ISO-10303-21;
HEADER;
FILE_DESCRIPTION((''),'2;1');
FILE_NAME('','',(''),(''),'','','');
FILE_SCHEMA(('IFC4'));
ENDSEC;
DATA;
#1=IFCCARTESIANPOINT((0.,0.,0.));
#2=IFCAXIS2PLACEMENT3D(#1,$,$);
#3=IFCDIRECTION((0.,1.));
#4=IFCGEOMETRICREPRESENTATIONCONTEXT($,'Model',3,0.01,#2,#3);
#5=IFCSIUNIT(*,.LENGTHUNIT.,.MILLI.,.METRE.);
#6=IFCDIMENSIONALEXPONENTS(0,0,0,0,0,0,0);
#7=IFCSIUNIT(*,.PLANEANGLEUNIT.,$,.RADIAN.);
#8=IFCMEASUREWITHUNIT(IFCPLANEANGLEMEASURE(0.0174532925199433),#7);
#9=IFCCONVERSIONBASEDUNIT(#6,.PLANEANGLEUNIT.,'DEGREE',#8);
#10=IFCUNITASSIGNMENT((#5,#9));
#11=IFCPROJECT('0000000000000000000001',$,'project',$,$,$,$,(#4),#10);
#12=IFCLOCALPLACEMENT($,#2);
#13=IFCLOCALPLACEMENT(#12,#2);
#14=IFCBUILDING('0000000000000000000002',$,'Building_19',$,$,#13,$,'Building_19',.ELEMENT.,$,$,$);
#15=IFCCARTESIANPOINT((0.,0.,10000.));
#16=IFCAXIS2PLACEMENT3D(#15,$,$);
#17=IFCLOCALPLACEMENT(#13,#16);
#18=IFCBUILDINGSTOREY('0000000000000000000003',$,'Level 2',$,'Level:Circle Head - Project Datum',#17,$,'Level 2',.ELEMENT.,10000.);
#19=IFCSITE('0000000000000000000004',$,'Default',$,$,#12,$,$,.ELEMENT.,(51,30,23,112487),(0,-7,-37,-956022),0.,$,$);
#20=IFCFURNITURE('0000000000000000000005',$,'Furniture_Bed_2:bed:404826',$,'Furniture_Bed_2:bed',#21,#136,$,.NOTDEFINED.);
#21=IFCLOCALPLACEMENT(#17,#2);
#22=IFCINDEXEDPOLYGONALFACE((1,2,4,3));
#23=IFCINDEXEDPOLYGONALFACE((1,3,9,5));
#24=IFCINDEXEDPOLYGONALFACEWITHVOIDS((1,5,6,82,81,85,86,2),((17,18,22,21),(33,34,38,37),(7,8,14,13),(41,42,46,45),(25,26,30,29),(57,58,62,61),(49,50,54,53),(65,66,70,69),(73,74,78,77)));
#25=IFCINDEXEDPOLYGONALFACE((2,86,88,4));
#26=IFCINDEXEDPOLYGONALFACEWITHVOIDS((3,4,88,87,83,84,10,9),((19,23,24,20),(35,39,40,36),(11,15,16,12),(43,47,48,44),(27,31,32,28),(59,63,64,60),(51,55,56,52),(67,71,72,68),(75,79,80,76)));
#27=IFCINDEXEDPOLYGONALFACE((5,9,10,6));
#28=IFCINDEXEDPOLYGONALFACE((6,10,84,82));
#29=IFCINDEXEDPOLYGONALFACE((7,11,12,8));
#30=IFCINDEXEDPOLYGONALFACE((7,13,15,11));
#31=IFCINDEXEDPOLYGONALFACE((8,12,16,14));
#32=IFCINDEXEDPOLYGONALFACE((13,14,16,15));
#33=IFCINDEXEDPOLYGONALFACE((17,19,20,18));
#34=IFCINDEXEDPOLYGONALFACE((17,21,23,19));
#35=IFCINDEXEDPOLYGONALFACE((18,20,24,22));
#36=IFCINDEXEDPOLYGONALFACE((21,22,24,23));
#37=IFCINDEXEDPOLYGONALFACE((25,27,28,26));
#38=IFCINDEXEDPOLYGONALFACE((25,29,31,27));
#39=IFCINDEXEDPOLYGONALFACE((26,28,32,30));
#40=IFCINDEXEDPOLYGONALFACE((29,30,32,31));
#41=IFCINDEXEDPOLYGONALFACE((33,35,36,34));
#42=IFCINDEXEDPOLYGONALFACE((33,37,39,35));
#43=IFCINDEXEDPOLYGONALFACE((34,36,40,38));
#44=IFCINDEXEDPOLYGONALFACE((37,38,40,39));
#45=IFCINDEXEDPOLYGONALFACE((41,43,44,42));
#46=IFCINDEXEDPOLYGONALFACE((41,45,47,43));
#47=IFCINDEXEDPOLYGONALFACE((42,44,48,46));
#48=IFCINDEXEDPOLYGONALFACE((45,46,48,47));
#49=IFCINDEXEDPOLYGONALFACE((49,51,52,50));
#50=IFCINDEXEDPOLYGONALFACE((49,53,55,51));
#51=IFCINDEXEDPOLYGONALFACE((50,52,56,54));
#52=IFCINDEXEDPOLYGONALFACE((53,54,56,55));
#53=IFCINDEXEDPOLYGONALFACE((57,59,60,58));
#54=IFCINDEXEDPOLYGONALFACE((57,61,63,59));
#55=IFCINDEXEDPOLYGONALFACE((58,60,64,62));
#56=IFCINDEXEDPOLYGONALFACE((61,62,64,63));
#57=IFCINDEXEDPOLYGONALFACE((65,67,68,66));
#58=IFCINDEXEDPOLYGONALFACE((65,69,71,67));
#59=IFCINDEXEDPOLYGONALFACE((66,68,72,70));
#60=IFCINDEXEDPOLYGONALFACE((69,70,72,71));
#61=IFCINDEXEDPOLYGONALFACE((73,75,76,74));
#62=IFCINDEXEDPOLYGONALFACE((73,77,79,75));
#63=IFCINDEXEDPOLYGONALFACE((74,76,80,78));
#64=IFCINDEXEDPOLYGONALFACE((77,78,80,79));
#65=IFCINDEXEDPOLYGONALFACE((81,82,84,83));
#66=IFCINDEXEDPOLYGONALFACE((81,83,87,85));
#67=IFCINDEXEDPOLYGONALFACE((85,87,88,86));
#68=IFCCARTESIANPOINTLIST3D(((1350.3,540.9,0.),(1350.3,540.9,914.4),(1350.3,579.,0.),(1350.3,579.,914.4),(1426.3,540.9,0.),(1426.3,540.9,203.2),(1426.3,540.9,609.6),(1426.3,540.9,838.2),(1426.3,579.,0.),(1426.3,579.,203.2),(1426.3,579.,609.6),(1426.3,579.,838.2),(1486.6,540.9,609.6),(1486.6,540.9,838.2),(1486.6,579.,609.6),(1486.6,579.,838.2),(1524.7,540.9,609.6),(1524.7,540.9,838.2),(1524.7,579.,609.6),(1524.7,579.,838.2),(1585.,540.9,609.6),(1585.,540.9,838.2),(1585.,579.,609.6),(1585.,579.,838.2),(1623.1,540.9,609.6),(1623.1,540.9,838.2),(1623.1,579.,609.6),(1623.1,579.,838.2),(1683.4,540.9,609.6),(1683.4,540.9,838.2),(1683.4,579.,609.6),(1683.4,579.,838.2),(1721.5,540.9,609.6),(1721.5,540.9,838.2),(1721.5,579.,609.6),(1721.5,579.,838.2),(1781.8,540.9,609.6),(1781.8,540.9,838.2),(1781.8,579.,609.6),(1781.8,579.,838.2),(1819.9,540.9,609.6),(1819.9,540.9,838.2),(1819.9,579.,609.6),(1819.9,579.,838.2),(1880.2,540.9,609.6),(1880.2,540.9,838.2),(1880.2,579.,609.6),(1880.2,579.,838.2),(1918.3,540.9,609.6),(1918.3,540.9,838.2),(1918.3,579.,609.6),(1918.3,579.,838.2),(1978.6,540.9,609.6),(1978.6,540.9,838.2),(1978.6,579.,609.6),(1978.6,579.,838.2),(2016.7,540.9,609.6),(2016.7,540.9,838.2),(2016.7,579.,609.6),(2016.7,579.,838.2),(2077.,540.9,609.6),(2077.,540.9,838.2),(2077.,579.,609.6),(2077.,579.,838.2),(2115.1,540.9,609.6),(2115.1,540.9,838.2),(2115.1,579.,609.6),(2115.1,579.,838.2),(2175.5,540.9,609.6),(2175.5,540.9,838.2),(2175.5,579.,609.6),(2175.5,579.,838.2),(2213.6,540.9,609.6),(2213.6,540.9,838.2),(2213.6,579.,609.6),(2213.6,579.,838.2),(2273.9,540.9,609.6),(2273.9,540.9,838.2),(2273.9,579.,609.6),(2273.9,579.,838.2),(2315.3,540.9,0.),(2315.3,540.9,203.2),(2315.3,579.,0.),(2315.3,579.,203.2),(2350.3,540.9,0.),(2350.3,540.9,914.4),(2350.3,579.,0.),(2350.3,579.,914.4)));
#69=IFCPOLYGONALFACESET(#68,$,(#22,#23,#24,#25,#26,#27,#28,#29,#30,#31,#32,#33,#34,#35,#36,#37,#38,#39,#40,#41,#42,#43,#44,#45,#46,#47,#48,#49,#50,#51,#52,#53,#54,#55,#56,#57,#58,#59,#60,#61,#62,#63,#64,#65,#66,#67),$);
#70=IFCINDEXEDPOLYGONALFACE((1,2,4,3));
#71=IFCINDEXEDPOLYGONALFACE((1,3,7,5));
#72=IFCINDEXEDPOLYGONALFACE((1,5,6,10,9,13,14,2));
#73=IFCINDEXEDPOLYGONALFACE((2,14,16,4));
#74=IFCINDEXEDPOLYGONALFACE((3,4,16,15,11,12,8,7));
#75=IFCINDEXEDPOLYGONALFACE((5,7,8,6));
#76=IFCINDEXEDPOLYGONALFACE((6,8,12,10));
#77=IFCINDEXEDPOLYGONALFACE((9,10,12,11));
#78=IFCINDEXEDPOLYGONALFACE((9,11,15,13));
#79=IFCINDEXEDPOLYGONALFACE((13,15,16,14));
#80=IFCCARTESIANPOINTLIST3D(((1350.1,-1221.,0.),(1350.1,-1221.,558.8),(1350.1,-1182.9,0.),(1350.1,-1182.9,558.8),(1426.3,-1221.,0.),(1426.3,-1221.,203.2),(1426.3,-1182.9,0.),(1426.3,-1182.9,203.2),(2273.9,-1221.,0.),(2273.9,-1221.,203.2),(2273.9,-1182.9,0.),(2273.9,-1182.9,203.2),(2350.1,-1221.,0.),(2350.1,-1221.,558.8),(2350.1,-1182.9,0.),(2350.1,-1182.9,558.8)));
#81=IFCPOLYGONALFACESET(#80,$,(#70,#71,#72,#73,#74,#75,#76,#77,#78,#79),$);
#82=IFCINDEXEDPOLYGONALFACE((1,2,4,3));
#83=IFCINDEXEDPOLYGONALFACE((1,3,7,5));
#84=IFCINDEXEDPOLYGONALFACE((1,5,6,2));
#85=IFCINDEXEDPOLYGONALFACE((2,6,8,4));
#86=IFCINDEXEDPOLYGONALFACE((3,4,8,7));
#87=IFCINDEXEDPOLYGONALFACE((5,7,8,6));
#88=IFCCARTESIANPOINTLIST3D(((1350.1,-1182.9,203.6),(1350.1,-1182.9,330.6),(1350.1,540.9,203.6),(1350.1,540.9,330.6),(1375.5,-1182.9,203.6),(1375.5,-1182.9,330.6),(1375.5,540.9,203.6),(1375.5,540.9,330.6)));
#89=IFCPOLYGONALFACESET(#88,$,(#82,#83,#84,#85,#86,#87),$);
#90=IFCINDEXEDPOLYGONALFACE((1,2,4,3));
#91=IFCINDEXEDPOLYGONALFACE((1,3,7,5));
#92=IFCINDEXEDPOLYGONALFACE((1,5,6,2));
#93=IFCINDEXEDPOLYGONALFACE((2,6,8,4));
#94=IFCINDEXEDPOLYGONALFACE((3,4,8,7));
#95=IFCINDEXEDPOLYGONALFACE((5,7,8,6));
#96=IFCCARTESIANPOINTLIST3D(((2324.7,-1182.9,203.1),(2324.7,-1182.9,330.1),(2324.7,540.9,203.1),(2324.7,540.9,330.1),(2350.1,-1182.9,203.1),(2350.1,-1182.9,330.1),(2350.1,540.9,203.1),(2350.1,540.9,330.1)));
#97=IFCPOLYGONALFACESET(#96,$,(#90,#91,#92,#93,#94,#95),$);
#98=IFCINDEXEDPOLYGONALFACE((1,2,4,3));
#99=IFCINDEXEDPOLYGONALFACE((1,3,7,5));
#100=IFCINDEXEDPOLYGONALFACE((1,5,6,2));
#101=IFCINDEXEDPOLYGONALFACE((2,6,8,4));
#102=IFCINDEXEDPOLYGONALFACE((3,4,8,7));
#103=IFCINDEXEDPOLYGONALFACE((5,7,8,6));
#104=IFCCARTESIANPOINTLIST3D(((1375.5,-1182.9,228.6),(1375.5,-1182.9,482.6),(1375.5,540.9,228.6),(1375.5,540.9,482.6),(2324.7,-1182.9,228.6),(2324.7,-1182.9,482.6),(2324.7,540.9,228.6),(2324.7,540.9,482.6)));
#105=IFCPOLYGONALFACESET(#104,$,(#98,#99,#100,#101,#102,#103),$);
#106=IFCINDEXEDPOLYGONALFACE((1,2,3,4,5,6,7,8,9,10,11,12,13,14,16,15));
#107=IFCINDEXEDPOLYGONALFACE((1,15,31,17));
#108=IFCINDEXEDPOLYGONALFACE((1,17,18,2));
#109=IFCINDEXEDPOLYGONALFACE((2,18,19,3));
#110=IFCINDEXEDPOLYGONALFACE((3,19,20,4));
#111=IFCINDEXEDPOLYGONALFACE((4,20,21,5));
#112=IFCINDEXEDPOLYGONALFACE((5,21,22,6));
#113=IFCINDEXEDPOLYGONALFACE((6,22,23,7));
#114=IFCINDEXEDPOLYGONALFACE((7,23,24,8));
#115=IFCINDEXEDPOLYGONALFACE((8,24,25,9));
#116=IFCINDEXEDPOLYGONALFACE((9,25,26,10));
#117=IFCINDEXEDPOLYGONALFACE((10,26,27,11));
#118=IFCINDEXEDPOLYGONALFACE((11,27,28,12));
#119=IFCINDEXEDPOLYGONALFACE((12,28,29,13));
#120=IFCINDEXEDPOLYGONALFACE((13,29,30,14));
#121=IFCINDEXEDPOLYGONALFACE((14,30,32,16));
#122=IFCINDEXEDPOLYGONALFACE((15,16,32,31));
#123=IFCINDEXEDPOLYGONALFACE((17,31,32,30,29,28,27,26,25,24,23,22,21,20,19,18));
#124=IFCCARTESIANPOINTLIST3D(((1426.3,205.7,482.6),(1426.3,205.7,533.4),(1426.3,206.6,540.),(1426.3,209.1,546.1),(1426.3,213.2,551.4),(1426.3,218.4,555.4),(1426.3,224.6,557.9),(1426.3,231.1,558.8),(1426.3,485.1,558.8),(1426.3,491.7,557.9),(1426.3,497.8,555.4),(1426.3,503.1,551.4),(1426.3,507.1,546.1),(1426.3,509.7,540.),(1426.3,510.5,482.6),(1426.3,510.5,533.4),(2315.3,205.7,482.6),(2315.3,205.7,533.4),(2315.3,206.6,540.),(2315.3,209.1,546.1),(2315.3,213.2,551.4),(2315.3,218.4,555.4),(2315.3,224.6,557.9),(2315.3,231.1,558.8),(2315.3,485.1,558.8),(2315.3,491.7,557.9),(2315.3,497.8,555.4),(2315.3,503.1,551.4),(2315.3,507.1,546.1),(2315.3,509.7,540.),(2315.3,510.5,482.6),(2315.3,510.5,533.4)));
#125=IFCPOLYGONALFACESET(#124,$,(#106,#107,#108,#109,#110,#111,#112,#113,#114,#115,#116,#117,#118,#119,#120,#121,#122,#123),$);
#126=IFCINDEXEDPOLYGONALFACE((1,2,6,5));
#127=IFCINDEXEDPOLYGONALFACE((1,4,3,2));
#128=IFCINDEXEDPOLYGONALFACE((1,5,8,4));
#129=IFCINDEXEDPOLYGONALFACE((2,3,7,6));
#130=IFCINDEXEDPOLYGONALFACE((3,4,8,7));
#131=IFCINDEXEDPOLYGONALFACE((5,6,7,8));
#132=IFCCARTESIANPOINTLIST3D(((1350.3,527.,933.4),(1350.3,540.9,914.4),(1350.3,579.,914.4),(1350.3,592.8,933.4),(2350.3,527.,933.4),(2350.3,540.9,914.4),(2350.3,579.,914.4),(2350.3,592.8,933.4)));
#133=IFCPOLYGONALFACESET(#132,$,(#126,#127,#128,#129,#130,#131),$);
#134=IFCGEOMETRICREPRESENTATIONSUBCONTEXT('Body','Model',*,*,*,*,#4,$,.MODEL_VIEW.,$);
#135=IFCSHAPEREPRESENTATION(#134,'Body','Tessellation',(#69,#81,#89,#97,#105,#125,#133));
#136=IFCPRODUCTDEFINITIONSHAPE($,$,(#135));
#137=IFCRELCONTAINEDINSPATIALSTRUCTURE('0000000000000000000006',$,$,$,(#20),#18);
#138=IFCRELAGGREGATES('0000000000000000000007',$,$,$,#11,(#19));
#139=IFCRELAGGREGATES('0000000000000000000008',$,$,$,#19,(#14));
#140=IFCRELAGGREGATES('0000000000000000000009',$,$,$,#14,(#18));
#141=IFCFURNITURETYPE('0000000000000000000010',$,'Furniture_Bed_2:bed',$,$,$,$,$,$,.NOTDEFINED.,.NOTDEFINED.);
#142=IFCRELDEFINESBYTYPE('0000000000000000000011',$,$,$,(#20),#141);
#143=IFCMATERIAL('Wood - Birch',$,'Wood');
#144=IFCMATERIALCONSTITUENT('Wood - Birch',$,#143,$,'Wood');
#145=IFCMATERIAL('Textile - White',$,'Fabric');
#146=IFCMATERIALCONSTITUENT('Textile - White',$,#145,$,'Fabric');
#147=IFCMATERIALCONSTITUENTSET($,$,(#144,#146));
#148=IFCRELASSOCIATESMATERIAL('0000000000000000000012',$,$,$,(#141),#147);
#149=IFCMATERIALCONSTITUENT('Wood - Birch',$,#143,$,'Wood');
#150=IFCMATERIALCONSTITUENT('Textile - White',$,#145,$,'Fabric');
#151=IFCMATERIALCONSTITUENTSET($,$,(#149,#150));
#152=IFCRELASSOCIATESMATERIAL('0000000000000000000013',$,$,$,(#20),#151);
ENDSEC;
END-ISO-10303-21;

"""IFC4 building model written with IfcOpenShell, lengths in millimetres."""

from ifc_helpers import new_model, entity, si_unit, converted_unit, direction, frame, origin, place, context, subcontext, project, spatial, line, arc, indexed_curve, outline, extrude, source, transform, mapped, material, constituent, constituent_set, type_object, type_shapes, element, save


model = new_model("IFC4")

# Units and contexts
model_context = context("Model", 3, precision=0.01, world=origin(), true_north=direction((0.0, 1.0)))
body_context = subcontext(model_context, "Body", "Model", "MODEL_VIEW")
ifc_project = project(units=[si_unit("LENGTHUNIT", "METRE", prefix="MILLI"), converted_unit("PLANEANGLEUNIT", "DEGREE", entity("IfcPlaneAngleMeasure", 0.0174532925199433), si_unit("PLANEANGLEUNIT", "RADIAN"), dimensions=[0, 0, 0, 0, 0, 0, 0])], contexts=[model_context])

# Site, building, storey
site_placement = place(None, origin())
site = spatial("IfcSite", under=ifc_project, at=site_placement, Name="Default", CompositionType="ELEMENT", RefLatitude=(51, 30, 23, 112487), RefLongitude=(0, -7, -37, -956022), RefElevation=0.0)
building_placement = place(site_placement, origin())
building = spatial("IfcBuilding", under=site, at=building_placement, Name="Building_19", LongName="Building_19", CompositionType="ELEMENT")
storey_placement = place(building_placement, frame((0.0, 0.0, 10000.0)))
storey = spatial("IfcBuildingStorey", under=building, at=storey_placement, Name="Level 2", ObjectType="Level:Circle Head - Project Datum", LongName="Level 2", CompositionType="ELEMENT", Elevation=10000.0)

# Furniture
ifc_material_1 = material(Name="Wood - Birch", Category="Wood")
ifc_constituent_1 = constituent(ifc_material_1, Name="Wood - Birch", Category="Wood")
ifc_material_2 = material(Name="Textile - White", Category="Fabric")
ifc_constituent_2 = constituent(ifc_material_2, Name="Textile - White", Category="Fabric")
ifc_constituent_set_1 = constituent_set(constituents=[ifc_constituent_1, ifc_constituent_2])
ifc_constituent_3 = constituent(ifc_material_1, Name="Wood - Birch", Category="Wood")
ifc_constituent_4 = constituent(ifc_material_2, Name="Textile - White", Category="Fabric")
ifc_constituent_set_2 = constituent_set(constituents=[ifc_constituent_3, ifc_constituent_4])
furniture_type_1 = type_object("IfcFurnitureType", Name="Furniture_Bed_2:bed", AssemblyPlace="NOTDEFINED", PredefinedType="NOTDEFINED", material=ifc_constituent_set_2)
shared_shape_1 = source(origin(), body_context, "Body", "SweptSolid", [
    extrude(outline(indexed_curve([(-635.0, -489.8), (279.4, -489.8), (279.4, -454.7), (76.2, -454.7), (76.2, 434.3), (279.4, 434.3), (279.4, 510.3), (-635.0, 510.3), (-635.0, -489.8)], self_intersect=False), holes=[indexed_curve([(-558.8, 374.0), (-558.8, 434.3), (-330.2, 434.3), (-330.2, 374.0), (-558.8, 374.0)], self_intersect=False), indexed_curve([(-558.8, 275.5), (-558.8, 335.9), (-330.2, 335.9), (-330.2, 275.5), (-558.8, 275.5)], self_intersect=False), indexed_curve([(-558.8, 177.1), (-558.8, 237.4), (-330.2, 237.4), (-330.2, 177.1), (-558.8, 177.1)], self_intersect=False), indexed_curve([(-558.8, 78.7), (-558.8, 139.0), (-330.2, 139.0), (-330.2, 78.7), (-558.8, 78.7)], self_intersect=False), indexed_curve([(-558.8, -118.1), (-558.8, -57.8), (-330.2, -57.8), (-330.2, -118.1), (-558.8, -118.1)], self_intersect=False), indexed_curve([(-558.8, -216.5), (-558.8, -156.2), (-330.2, -156.2), (-330.2, -216.5), (-558.8, -216.5)], self_intersect=False), indexed_curve([(-558.8, -314.9), (-558.8, -254.6), (-330.2, -254.6), (-330.2, -314.9), (-558.8, -314.9)], self_intersect=False), indexed_curve([(-558.8, -413.3), (-558.8, -353.0), (-330.2, -353.0), (-330.2, -413.3), (-558.8, -413.3)], self_intersect=False), indexed_curve([(-558.8, -19.7), (-558.8, 40.6), (-330.2, 40.6), (-330.2, -19.7), (-558.8, -19.7)], self_intersect=False)]), frame((-8.6, -38.1, 279.4), z_axis=(0.0, 1.0, 0.0), x_axis=(0.0, 0.0, -1.0)), (0.0, 0.0, 1.0), 38.1),
    extrude(outline(indexed_curve([(423.8, -190.5), (500.0, -190.5), (500.0, 368.3), (-500.0, 368.3), (-500.0, -190.5), (-423.8, -190.5), (-423.8, 12.7), (423.8, 12.7), (423.8, -190.5)], self_intersect=False)), frame((-19.1, -1800.0, 190.5), z_axis=(0.0, 1.0, 0.0), x_axis=(-1.0, 0.0, 0.0)), (0.0, 0.0, 1.0), 38.1),
    extrude(outline(indexed_curve([(-12.7, -861.9), (12.7, -861.9), (12.7, 861.9), (-12.7, 861.9), (-12.7, -861.9)], self_intersect=False)), frame((-506.4, -900.0, 203.6)), (0.0, 0.0, 1.0), 127.0),
    extrude(outline(indexed_curve([(-12.7, -861.9), (12.7, -861.9), (12.7, 861.9), (-12.7, 861.9), (-12.7, -861.9)], self_intersect=False)), frame((468.2, -900.0, 203.1)), (0.0, 0.0, 1.0), 127.0),
    extrude(outline(indexed_curve([(-474.6, -861.9), (474.6, -861.9), (474.6, 861.9), (-474.6, 861.9), (-474.6, -861.9)], self_intersect=False)), frame((-19.0, -900.0, 228.6), z_axis=(0.0, 0.0, 1.0), x_axis=(-1.0, 0.0, 0.0)), (0.0, 0.0, 1.0), 254.0),
    extrude(outline(indexed_curve([(-152.4, -42.3), (152.4, -42.3), (152.4, 8.5), (145.0, 26.4), (127.0, 33.9), (-127.0, 33.9), (-145.0, 26.4), (-152.4, 8.5)], segments=[line(1, 2, 3), arc(3, 4, 5), line(5, 6), arc(6, 7, 8), line(8, 1)], self_intersect=False)), frame((-442.9, -220.8, 524.9), z_axis=(1.0, 0.0, 0.0), x_axis=(0.0, 1.0, 0.0)), (0.0, 0.0, 1.0), 889.0),
    extrude(outline(indexed_curve([(-19.1, -9.5), (19.0, -9.5), (32.9, 9.5), (-32.9, 9.5), (-19.1, -9.5)], self_intersect=False)), frame((-518.8, -19.0, 923.9), z_axis=(1.0, 0.0, 0.0), x_axis=(0.0, 1.0, 0.0)), (0.0, 0.0, 1.0), 1000.1),
])
type_shapes(furniture_type_1, [shared_shape_1])
furniture_1_placement = place(storey_placement, frame((1869.1, 579.0, 0.0)))
element("IfcFurniture", 1, at=furniture_1_placement, inside=storey, type_object=furniture_type_1, material=ifc_constituent_set_1, Name="Furniture_Bed_2:bed:404826", ObjectType="Furniture_Bed_2:bed", PredefinedType="NOTDEFINED", context=body_context, shape_type="MappedRepresentation", body=[
    mapped(shared_shape_1, transform((0.0, 0.0, 0.0), scale=1.0)),
])

save(model, "model.ifc")
